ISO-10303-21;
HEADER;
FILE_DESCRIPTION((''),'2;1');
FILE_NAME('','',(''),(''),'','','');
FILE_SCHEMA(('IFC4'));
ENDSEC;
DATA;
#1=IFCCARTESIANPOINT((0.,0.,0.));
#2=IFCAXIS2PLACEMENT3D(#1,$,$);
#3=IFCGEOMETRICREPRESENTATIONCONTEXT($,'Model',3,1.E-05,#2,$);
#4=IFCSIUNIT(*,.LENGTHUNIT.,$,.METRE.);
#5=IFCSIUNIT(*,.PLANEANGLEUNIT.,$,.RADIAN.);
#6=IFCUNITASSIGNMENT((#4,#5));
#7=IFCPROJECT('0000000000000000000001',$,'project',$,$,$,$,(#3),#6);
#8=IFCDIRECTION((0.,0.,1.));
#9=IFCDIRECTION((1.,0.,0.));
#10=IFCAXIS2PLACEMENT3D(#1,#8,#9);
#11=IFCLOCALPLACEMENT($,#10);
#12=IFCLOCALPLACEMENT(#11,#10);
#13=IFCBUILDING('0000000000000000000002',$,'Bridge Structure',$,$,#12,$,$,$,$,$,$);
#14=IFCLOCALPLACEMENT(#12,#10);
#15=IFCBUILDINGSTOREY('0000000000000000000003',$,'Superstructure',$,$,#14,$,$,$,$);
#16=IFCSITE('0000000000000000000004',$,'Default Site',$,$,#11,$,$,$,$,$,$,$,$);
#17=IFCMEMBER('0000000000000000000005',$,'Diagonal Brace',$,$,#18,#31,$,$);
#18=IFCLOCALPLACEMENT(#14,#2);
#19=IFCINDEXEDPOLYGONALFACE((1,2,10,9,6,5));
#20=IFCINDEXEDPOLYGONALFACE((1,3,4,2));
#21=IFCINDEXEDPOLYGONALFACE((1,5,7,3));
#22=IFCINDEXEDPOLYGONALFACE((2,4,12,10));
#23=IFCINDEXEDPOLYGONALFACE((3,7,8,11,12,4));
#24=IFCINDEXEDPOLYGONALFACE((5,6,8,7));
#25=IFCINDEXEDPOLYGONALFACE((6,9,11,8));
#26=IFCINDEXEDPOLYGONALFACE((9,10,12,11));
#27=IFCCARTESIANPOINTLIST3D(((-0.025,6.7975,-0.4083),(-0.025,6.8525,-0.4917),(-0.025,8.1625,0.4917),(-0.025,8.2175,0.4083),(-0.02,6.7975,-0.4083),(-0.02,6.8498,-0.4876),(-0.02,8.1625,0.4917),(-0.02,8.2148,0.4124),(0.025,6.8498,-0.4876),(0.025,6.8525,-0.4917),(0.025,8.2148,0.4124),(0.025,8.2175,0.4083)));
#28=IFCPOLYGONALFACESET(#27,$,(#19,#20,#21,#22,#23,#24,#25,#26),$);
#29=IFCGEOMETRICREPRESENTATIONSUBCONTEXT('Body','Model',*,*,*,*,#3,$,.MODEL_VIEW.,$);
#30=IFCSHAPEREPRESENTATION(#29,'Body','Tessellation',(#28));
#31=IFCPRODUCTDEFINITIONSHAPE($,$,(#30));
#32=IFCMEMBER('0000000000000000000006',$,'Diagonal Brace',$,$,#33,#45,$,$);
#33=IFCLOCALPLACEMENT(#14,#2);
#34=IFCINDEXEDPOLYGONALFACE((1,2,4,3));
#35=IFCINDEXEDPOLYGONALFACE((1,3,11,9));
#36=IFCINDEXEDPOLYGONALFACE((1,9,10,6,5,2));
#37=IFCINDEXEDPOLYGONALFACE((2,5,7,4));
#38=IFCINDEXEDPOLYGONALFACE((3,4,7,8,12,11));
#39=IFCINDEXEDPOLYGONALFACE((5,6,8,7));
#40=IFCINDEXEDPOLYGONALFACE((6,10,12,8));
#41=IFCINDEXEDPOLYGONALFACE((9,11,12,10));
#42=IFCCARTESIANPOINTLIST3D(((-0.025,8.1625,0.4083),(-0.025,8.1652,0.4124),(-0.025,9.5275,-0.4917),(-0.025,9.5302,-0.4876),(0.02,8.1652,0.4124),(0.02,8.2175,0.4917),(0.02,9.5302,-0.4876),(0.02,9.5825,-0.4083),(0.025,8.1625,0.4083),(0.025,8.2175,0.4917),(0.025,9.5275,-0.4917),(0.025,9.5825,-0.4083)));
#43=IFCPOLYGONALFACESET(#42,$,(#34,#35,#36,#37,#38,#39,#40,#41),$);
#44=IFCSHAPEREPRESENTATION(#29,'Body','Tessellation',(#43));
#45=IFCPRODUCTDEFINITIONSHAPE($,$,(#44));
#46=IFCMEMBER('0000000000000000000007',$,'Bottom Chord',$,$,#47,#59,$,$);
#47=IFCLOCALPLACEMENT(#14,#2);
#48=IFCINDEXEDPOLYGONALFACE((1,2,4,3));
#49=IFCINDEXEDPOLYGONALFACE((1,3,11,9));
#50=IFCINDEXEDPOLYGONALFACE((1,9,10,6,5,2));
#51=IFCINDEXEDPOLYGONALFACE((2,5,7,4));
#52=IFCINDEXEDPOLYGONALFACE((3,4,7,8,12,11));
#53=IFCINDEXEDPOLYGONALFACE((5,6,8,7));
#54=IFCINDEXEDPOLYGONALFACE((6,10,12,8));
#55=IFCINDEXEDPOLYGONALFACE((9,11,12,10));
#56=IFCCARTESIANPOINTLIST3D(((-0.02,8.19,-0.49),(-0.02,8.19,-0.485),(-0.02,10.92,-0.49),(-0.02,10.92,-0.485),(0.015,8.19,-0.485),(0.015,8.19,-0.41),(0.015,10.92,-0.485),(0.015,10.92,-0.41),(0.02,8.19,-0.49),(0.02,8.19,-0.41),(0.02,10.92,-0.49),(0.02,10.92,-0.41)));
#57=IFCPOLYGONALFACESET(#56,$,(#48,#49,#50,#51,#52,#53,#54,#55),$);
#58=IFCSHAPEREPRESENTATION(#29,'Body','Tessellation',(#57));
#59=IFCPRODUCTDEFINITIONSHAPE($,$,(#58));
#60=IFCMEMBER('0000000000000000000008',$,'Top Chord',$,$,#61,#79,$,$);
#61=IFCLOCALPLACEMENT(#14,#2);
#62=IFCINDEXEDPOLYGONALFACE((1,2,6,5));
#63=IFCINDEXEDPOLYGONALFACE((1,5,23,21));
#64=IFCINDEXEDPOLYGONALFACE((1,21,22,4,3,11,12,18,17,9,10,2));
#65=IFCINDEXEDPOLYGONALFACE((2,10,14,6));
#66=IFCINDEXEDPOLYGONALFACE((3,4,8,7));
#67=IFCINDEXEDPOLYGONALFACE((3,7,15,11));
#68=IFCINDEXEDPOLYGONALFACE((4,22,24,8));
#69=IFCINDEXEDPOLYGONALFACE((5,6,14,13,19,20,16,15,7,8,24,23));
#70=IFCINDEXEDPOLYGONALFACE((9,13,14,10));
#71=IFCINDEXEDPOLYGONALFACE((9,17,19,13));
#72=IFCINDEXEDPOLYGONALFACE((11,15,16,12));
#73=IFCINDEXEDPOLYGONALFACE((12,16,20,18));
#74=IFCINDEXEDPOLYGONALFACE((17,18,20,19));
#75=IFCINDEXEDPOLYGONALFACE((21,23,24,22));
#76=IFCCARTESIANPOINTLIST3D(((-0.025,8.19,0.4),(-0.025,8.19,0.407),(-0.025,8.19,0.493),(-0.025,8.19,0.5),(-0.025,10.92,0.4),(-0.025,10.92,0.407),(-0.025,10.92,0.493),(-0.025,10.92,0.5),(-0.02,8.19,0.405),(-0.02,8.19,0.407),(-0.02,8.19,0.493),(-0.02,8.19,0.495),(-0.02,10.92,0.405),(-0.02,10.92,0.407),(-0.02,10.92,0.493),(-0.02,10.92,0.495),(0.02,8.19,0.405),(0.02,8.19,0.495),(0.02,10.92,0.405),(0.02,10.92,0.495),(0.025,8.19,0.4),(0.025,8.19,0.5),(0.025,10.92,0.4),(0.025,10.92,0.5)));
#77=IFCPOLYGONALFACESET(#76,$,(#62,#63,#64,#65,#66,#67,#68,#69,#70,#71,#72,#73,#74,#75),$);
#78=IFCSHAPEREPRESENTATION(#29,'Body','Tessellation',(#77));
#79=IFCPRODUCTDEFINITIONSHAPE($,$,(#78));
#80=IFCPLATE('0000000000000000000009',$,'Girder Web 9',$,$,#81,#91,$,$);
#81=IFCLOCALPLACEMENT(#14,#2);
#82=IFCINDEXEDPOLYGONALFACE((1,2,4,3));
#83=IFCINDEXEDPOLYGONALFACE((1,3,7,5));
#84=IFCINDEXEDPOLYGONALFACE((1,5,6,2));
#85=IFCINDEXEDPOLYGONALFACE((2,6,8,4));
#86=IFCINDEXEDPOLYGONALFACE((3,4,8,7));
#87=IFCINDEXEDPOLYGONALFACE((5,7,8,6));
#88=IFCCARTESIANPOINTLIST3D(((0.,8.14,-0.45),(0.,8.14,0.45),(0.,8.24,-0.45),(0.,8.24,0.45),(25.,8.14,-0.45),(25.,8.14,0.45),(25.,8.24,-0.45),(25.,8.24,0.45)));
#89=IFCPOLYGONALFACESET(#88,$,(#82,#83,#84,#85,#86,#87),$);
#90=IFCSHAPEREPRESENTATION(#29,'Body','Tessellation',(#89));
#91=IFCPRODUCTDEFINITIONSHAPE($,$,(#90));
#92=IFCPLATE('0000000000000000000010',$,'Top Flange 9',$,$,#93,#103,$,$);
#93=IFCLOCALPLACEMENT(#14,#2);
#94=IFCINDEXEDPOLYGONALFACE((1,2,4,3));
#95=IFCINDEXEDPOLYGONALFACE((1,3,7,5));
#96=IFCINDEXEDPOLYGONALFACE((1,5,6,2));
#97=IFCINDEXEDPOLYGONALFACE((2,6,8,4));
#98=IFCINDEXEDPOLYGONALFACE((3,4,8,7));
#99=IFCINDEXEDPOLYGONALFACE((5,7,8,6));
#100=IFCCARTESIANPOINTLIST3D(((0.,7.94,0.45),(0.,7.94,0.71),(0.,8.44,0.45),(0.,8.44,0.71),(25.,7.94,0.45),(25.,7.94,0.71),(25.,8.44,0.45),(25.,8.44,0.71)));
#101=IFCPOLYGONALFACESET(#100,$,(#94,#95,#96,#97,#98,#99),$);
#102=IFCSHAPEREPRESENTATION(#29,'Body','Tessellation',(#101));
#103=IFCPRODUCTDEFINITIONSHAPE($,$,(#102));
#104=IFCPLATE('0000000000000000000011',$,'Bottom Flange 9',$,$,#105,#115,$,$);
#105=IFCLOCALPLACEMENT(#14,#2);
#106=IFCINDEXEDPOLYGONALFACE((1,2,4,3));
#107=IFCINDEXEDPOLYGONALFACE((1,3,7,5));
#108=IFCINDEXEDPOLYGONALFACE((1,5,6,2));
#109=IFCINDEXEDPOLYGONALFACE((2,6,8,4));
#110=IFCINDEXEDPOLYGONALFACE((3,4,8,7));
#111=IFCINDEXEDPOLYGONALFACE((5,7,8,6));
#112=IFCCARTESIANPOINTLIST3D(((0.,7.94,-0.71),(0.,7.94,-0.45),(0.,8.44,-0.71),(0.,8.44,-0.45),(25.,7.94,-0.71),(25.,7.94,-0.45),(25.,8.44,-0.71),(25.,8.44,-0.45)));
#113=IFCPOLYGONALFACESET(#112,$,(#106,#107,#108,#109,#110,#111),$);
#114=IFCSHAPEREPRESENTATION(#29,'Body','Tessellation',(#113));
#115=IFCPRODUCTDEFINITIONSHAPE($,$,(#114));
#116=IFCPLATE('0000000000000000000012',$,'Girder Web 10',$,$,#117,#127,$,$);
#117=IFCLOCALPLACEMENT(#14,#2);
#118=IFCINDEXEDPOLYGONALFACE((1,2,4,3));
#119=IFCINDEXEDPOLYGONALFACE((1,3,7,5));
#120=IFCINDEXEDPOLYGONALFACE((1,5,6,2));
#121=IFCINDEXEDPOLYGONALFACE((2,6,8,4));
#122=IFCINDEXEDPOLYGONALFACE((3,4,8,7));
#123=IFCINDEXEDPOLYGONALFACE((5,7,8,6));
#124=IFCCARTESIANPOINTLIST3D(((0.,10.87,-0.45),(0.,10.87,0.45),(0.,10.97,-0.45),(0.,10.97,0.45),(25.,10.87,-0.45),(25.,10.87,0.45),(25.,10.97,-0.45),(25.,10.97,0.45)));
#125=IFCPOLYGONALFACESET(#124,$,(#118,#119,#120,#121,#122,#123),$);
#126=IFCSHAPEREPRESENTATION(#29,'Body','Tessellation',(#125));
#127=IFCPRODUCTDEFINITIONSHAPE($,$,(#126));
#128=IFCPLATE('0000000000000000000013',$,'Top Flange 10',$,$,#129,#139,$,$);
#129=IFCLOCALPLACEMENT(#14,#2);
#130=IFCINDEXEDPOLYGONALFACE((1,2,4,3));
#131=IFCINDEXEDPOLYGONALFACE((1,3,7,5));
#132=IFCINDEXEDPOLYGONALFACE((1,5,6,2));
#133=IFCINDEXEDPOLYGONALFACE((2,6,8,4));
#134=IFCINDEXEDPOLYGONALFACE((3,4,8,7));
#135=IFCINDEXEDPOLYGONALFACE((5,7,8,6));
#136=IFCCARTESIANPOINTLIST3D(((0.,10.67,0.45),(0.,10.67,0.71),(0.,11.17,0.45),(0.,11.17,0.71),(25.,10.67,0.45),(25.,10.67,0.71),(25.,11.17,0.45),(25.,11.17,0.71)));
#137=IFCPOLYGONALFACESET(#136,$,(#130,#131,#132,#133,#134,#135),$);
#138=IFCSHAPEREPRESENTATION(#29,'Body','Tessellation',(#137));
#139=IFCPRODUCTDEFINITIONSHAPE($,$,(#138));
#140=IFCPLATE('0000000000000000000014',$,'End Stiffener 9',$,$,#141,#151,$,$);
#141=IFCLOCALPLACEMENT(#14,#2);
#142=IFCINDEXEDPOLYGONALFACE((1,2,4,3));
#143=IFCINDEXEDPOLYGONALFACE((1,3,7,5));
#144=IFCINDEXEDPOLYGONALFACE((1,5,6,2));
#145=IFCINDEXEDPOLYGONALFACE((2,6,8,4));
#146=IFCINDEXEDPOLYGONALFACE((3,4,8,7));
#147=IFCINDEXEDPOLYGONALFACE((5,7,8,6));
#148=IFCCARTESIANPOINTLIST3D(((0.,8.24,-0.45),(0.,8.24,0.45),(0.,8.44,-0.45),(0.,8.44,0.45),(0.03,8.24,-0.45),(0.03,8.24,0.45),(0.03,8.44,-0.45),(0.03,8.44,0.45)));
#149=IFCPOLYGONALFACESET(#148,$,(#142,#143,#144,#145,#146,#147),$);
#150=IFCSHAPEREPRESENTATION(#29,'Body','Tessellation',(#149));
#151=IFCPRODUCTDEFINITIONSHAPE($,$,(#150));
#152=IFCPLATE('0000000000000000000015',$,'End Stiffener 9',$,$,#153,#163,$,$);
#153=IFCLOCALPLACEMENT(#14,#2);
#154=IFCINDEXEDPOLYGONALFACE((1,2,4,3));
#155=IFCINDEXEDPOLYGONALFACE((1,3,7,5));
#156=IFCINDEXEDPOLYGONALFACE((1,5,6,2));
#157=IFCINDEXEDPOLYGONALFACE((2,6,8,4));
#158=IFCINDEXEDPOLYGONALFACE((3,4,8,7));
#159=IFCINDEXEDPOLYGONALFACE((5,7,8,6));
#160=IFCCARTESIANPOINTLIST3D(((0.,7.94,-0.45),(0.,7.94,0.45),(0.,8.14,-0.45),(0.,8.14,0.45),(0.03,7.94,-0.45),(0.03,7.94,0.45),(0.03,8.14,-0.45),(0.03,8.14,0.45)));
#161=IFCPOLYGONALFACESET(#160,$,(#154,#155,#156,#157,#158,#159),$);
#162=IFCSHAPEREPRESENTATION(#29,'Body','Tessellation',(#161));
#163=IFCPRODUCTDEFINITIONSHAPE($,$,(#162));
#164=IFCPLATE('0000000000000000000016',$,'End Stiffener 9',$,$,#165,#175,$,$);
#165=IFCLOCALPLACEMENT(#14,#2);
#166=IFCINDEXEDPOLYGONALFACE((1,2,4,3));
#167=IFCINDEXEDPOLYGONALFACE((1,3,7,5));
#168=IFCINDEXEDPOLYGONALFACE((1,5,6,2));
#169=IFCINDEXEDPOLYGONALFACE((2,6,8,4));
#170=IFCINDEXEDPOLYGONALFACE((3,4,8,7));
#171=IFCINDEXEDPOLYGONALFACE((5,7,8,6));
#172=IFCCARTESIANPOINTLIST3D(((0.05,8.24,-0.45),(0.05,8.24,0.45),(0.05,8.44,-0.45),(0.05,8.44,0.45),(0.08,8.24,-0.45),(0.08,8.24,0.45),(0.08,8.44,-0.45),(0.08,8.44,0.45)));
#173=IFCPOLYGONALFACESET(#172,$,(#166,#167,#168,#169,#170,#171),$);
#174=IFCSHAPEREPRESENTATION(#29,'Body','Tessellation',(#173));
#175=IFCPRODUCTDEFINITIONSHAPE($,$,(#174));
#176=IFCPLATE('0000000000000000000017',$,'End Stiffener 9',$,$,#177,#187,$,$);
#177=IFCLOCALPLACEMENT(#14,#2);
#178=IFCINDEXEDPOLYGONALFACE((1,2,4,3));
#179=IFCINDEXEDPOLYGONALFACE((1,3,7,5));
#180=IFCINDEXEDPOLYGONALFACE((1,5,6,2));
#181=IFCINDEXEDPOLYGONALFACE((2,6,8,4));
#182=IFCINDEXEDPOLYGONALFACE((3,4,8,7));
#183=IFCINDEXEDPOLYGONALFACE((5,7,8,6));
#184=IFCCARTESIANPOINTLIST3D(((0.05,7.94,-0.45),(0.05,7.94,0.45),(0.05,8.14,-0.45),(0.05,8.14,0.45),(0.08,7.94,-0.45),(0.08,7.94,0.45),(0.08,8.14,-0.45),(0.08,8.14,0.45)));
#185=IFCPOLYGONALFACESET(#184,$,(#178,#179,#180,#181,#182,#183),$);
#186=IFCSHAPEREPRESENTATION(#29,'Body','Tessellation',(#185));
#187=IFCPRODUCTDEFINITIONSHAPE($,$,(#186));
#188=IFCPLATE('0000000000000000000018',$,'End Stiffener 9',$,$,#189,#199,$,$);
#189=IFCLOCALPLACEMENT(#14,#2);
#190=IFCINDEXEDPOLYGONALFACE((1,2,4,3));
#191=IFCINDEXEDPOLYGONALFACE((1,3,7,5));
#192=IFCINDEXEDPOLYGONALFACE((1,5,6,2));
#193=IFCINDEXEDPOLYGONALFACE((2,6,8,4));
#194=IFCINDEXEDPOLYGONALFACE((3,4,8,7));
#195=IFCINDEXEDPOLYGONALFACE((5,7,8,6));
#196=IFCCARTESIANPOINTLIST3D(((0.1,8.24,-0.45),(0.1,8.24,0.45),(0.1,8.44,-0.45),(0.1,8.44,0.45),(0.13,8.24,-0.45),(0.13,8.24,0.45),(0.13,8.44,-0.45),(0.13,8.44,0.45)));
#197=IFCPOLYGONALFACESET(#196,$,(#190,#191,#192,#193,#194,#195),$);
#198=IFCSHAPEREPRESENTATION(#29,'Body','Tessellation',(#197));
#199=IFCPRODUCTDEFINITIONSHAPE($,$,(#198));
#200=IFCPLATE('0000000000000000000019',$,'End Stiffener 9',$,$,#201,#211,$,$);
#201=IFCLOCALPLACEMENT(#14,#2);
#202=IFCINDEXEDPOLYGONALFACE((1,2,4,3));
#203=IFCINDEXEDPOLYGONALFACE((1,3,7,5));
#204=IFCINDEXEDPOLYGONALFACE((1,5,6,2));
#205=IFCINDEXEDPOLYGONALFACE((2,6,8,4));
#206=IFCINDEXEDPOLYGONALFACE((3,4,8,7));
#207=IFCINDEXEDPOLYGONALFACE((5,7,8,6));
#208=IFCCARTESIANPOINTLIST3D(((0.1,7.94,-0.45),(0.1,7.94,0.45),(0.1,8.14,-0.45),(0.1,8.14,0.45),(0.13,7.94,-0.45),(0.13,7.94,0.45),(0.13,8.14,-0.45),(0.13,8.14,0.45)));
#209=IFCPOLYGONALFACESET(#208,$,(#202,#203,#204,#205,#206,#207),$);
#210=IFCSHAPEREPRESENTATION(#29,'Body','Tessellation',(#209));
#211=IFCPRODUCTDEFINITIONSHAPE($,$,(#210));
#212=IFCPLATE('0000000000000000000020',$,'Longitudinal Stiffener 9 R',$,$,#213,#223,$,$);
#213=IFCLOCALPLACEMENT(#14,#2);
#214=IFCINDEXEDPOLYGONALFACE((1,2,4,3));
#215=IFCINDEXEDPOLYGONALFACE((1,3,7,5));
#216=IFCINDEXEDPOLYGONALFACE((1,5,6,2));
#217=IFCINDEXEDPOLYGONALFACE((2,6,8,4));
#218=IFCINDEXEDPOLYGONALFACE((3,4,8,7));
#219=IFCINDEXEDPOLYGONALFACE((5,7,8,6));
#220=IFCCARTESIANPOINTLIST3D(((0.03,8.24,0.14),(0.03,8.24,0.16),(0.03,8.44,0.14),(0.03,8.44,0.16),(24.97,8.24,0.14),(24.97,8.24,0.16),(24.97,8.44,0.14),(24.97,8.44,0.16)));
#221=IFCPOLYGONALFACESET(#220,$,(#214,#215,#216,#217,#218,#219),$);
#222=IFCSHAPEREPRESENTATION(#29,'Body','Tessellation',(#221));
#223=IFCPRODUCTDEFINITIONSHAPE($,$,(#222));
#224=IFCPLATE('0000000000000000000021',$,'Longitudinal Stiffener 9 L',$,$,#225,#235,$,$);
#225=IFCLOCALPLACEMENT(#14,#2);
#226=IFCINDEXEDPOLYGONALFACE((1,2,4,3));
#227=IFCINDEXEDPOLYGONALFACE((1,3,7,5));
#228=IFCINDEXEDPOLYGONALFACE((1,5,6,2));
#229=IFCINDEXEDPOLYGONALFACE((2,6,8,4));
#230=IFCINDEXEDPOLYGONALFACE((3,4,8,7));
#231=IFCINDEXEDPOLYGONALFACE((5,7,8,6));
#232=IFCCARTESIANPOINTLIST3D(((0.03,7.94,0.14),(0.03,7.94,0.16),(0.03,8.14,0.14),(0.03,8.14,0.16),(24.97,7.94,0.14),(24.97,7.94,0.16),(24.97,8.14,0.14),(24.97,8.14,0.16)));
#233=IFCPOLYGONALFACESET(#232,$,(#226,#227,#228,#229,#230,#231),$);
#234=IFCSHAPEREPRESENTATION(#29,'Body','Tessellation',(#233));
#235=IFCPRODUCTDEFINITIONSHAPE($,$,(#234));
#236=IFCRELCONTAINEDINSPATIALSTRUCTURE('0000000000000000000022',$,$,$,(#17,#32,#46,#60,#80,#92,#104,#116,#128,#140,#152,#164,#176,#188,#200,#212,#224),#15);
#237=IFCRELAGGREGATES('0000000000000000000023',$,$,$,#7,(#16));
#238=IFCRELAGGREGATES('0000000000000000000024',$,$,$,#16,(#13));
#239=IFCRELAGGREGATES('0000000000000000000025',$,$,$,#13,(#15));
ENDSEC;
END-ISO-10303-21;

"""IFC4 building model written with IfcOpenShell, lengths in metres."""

from ifc_helpers import new_model, si_unit, frame, origin, origin_with_axes, origin_2d_with_axis, place, context, subcontext, project, spatial, rectangle, l_section, c_section, extrude, element, save


model = new_model("IFC4")

# Units and contexts
model_context = context("Model", 3, precision=1e-05, world=origin())
body_context = subcontext(model_context, "Body", "Model", "MODEL_VIEW")
ifc_project = project(units=[si_unit("LENGTHUNIT", "METRE"), si_unit("PLANEANGLEUNIT", "RADIAN")], contexts=[model_context])

# Site, building, storey
site_placement = place(None, origin_with_axes())
site = spatial("IfcSite", under=ifc_project, at=site_placement, Name="Default Site")
building_placement = place(site_placement, origin_with_axes())
building = spatial("IfcBuilding", under=site, at=building_placement, Name="Bridge Structure")
storey_placement = place(building_placement, origin_with_axes())
storey = spatial("IfcBuildingStorey", under=building, at=storey_placement, Name="Superstructure")

# Members
for number, where, z_axis, x_axis, name in (
    (1, (0.0, 8.19, 0.45), (0.0, -0.834862, -0.550459), (1.0, 0.0, 0.0), "Diagonal Brace"),
    (2, (0.0, 8.19, 0.45), (0.0, 0.834862, -0.550459), (-1.0, 0.0, 0.0), "Diagonal Brace"),
):
    element("IfcMember", number, at=place(storey_placement, frame(where, z_axis=z_axis, x_axis=x_axis)), inside=storey, Name=name, context=body_context, shape_type="SweptSolid", body=[
        extrude(l_section(Depth=0.1, Width=0.05, Thickness=0.005, at=origin_2d_with_axis()), origin_with_axes(), (0.0, 0.0, 1.0), 1.635),
    ])
member_1_placement = place(storey_placement, frame((0.0, 8.19, -0.45), z_axis=(0.0, 1.0, 0.0), x_axis=(-1.0, 0.0, 0.0)))
element("IfcMember", 3, at=member_1_placement, inside=storey, Name="Bottom Chord", context=body_context, shape_type="SweptSolid", body=[
    extrude(l_section(Depth=0.08, Width=0.04, Thickness=0.005, at=origin_2d_with_axis()), origin_with_axes(), (0.0, 0.0, 1.0), 2.73),
])
member_2_placement = place(storey_placement, frame((0.0, 8.19, 0.45), z_axis=(0.0, 1.0, 0.0), x_axis=(-1.0, 0.0, 0.0)))
element("IfcMember", 4, at=member_2_placement, inside=storey, Name="Top Chord", context=body_context, shape_type="SweptSolid", body=[
    extrude(c_section(Depth=0.1, Width=0.05, WallThickness=0.005, Girth=0.007, at=origin_2d_with_axis()), origin_with_axes(), (0.0, 0.0, 1.0), 2.73),
])

# Plates
plate_1_placement = place(storey_placement, frame((0.0, 8.19, 0.0), z_axis=(1.0, 0.0, 0.0), x_axis=(0.0, 1.0, 0.0)))
element("IfcPlate", 5, at=plate_1_placement, inside=storey, Name="Girder Web 9", context=body_context, shape_type="SweptSolid", body=[
    extrude(rectangle(XDim=0.1, YDim=0.9, at=origin_2d_with_axis()), origin_with_axes(), (0.0, 0.0, 1.0), 25.0),
])
for number, where, z_axis, x_axis, name in (
    (6, (0.0, 8.19, 0.58), (1.0, 0.0, 0.0), (0.0, 1.0, 0.0), "Top Flange 9"),
    (7, (0.0, 8.19, -0.58), (1.0, 0.0, 0.0), (0.0, 1.0, 0.0), "Bottom Flange 9"),
):
    element("IfcPlate", number, at=place(storey_placement, frame(where, z_axis=z_axis, x_axis=x_axis)), inside=storey, Name=name, context=body_context, shape_type="SweptSolid", body=[
        extrude(rectangle(XDim=0.5, YDim=0.26, at=origin_2d_with_axis()), origin_with_axes(), (0.0, 0.0, 1.0), 25.0),
    ])
plate_2_placement = place(storey_placement, frame((0.0, 10.92, 0.0), z_axis=(1.0, 0.0, 0.0), x_axis=(0.0, 1.0, 0.0)))
element("IfcPlate", 8, at=plate_2_placement, inside=storey, Name="Girder Web 10", context=body_context, shape_type="SweptSolid", body=[
    extrude(rectangle(XDim=0.1, YDim=0.9, at=origin_2d_with_axis()), origin_with_axes(), (0.0, 0.0, 1.0), 25.0),
])
plate_3_placement = place(storey_placement, frame((0.0, 10.92, 0.58), z_axis=(1.0, 0.0, 0.0), x_axis=(0.0, 1.0, 0.0)))
element("IfcPlate", 9, at=plate_3_placement, inside=storey, Name="Top Flange 10", context=body_context, shape_type="SweptSolid", body=[
    extrude(rectangle(XDim=0.5, YDim=0.26, at=origin_2d_with_axis()), origin_with_axes(), (0.0, 0.0, 1.0), 25.0),
])
for number, where, z_axis, x_axis, name in (
    (10, (0.015, 8.34, -0.45), (0.0, 0.0, 1.0), (1.0, 0.0, 0.0), "End Stiffener 9"),
    (11, (0.015, 8.04, -0.45), (0.0, 0.0, 1.0), (1.0, 0.0, 0.0), "End Stiffener 9"),
    (12, (0.065, 8.34, -0.45), (0.0, 0.0, 1.0), (1.0, 0.0, 0.0), "End Stiffener 9"),
    (13, (0.065, 8.04, -0.45), (0.0, 0.0, 1.0), (1.0, 0.0, 0.0), "End Stiffener 9"),
    (14, (0.115, 8.34, -0.45), (0.0, 0.0, 1.0), (1.0, 0.0, 0.0), "End Stiffener 9"),
    (15, (0.115, 8.04, -0.45), (0.0, 0.0, 1.0), (1.0, 0.0, 0.0), "End Stiffener 9"),
):
    element("IfcPlate", number, at=place(storey_placement, frame(where, z_axis=z_axis, x_axis=x_axis)), inside=storey, Name=name, context=body_context, shape_type="SweptSolid", body=[
        extrude(rectangle(XDim=0.03, YDim=0.2, at=origin_2d_with_axis()), origin_with_axes(), (0.0, 0.0, 1.0), 0.9),
    ])
for number, where, z_axis, x_axis, name in (
    (16, (0.03, 8.34, 0.15), (1.0, 0.0, 0.0), (0.0, 1.0, 0.0), "Longitudinal Stiffener 9 R"),
    (17, (0.03, 8.04, 0.15), (1.0, 0.0, 0.0), (0.0, 1.0, 0.0), "Longitudinal Stiffener 9 L"),
):
    element("IfcPlate", number, at=place(storey_placement, frame(where, z_axis=z_axis, x_axis=x_axis)), inside=storey, Name=name, context=body_context, shape_type="SweptSolid", body=[
        extrude(rectangle(XDim=0.2, YDim=0.02, at=origin_2d_with_axis()), origin_with_axes(), (0.0, 0.0, 1.0), 24.94),
    ])

save(model, "model.ifc")
